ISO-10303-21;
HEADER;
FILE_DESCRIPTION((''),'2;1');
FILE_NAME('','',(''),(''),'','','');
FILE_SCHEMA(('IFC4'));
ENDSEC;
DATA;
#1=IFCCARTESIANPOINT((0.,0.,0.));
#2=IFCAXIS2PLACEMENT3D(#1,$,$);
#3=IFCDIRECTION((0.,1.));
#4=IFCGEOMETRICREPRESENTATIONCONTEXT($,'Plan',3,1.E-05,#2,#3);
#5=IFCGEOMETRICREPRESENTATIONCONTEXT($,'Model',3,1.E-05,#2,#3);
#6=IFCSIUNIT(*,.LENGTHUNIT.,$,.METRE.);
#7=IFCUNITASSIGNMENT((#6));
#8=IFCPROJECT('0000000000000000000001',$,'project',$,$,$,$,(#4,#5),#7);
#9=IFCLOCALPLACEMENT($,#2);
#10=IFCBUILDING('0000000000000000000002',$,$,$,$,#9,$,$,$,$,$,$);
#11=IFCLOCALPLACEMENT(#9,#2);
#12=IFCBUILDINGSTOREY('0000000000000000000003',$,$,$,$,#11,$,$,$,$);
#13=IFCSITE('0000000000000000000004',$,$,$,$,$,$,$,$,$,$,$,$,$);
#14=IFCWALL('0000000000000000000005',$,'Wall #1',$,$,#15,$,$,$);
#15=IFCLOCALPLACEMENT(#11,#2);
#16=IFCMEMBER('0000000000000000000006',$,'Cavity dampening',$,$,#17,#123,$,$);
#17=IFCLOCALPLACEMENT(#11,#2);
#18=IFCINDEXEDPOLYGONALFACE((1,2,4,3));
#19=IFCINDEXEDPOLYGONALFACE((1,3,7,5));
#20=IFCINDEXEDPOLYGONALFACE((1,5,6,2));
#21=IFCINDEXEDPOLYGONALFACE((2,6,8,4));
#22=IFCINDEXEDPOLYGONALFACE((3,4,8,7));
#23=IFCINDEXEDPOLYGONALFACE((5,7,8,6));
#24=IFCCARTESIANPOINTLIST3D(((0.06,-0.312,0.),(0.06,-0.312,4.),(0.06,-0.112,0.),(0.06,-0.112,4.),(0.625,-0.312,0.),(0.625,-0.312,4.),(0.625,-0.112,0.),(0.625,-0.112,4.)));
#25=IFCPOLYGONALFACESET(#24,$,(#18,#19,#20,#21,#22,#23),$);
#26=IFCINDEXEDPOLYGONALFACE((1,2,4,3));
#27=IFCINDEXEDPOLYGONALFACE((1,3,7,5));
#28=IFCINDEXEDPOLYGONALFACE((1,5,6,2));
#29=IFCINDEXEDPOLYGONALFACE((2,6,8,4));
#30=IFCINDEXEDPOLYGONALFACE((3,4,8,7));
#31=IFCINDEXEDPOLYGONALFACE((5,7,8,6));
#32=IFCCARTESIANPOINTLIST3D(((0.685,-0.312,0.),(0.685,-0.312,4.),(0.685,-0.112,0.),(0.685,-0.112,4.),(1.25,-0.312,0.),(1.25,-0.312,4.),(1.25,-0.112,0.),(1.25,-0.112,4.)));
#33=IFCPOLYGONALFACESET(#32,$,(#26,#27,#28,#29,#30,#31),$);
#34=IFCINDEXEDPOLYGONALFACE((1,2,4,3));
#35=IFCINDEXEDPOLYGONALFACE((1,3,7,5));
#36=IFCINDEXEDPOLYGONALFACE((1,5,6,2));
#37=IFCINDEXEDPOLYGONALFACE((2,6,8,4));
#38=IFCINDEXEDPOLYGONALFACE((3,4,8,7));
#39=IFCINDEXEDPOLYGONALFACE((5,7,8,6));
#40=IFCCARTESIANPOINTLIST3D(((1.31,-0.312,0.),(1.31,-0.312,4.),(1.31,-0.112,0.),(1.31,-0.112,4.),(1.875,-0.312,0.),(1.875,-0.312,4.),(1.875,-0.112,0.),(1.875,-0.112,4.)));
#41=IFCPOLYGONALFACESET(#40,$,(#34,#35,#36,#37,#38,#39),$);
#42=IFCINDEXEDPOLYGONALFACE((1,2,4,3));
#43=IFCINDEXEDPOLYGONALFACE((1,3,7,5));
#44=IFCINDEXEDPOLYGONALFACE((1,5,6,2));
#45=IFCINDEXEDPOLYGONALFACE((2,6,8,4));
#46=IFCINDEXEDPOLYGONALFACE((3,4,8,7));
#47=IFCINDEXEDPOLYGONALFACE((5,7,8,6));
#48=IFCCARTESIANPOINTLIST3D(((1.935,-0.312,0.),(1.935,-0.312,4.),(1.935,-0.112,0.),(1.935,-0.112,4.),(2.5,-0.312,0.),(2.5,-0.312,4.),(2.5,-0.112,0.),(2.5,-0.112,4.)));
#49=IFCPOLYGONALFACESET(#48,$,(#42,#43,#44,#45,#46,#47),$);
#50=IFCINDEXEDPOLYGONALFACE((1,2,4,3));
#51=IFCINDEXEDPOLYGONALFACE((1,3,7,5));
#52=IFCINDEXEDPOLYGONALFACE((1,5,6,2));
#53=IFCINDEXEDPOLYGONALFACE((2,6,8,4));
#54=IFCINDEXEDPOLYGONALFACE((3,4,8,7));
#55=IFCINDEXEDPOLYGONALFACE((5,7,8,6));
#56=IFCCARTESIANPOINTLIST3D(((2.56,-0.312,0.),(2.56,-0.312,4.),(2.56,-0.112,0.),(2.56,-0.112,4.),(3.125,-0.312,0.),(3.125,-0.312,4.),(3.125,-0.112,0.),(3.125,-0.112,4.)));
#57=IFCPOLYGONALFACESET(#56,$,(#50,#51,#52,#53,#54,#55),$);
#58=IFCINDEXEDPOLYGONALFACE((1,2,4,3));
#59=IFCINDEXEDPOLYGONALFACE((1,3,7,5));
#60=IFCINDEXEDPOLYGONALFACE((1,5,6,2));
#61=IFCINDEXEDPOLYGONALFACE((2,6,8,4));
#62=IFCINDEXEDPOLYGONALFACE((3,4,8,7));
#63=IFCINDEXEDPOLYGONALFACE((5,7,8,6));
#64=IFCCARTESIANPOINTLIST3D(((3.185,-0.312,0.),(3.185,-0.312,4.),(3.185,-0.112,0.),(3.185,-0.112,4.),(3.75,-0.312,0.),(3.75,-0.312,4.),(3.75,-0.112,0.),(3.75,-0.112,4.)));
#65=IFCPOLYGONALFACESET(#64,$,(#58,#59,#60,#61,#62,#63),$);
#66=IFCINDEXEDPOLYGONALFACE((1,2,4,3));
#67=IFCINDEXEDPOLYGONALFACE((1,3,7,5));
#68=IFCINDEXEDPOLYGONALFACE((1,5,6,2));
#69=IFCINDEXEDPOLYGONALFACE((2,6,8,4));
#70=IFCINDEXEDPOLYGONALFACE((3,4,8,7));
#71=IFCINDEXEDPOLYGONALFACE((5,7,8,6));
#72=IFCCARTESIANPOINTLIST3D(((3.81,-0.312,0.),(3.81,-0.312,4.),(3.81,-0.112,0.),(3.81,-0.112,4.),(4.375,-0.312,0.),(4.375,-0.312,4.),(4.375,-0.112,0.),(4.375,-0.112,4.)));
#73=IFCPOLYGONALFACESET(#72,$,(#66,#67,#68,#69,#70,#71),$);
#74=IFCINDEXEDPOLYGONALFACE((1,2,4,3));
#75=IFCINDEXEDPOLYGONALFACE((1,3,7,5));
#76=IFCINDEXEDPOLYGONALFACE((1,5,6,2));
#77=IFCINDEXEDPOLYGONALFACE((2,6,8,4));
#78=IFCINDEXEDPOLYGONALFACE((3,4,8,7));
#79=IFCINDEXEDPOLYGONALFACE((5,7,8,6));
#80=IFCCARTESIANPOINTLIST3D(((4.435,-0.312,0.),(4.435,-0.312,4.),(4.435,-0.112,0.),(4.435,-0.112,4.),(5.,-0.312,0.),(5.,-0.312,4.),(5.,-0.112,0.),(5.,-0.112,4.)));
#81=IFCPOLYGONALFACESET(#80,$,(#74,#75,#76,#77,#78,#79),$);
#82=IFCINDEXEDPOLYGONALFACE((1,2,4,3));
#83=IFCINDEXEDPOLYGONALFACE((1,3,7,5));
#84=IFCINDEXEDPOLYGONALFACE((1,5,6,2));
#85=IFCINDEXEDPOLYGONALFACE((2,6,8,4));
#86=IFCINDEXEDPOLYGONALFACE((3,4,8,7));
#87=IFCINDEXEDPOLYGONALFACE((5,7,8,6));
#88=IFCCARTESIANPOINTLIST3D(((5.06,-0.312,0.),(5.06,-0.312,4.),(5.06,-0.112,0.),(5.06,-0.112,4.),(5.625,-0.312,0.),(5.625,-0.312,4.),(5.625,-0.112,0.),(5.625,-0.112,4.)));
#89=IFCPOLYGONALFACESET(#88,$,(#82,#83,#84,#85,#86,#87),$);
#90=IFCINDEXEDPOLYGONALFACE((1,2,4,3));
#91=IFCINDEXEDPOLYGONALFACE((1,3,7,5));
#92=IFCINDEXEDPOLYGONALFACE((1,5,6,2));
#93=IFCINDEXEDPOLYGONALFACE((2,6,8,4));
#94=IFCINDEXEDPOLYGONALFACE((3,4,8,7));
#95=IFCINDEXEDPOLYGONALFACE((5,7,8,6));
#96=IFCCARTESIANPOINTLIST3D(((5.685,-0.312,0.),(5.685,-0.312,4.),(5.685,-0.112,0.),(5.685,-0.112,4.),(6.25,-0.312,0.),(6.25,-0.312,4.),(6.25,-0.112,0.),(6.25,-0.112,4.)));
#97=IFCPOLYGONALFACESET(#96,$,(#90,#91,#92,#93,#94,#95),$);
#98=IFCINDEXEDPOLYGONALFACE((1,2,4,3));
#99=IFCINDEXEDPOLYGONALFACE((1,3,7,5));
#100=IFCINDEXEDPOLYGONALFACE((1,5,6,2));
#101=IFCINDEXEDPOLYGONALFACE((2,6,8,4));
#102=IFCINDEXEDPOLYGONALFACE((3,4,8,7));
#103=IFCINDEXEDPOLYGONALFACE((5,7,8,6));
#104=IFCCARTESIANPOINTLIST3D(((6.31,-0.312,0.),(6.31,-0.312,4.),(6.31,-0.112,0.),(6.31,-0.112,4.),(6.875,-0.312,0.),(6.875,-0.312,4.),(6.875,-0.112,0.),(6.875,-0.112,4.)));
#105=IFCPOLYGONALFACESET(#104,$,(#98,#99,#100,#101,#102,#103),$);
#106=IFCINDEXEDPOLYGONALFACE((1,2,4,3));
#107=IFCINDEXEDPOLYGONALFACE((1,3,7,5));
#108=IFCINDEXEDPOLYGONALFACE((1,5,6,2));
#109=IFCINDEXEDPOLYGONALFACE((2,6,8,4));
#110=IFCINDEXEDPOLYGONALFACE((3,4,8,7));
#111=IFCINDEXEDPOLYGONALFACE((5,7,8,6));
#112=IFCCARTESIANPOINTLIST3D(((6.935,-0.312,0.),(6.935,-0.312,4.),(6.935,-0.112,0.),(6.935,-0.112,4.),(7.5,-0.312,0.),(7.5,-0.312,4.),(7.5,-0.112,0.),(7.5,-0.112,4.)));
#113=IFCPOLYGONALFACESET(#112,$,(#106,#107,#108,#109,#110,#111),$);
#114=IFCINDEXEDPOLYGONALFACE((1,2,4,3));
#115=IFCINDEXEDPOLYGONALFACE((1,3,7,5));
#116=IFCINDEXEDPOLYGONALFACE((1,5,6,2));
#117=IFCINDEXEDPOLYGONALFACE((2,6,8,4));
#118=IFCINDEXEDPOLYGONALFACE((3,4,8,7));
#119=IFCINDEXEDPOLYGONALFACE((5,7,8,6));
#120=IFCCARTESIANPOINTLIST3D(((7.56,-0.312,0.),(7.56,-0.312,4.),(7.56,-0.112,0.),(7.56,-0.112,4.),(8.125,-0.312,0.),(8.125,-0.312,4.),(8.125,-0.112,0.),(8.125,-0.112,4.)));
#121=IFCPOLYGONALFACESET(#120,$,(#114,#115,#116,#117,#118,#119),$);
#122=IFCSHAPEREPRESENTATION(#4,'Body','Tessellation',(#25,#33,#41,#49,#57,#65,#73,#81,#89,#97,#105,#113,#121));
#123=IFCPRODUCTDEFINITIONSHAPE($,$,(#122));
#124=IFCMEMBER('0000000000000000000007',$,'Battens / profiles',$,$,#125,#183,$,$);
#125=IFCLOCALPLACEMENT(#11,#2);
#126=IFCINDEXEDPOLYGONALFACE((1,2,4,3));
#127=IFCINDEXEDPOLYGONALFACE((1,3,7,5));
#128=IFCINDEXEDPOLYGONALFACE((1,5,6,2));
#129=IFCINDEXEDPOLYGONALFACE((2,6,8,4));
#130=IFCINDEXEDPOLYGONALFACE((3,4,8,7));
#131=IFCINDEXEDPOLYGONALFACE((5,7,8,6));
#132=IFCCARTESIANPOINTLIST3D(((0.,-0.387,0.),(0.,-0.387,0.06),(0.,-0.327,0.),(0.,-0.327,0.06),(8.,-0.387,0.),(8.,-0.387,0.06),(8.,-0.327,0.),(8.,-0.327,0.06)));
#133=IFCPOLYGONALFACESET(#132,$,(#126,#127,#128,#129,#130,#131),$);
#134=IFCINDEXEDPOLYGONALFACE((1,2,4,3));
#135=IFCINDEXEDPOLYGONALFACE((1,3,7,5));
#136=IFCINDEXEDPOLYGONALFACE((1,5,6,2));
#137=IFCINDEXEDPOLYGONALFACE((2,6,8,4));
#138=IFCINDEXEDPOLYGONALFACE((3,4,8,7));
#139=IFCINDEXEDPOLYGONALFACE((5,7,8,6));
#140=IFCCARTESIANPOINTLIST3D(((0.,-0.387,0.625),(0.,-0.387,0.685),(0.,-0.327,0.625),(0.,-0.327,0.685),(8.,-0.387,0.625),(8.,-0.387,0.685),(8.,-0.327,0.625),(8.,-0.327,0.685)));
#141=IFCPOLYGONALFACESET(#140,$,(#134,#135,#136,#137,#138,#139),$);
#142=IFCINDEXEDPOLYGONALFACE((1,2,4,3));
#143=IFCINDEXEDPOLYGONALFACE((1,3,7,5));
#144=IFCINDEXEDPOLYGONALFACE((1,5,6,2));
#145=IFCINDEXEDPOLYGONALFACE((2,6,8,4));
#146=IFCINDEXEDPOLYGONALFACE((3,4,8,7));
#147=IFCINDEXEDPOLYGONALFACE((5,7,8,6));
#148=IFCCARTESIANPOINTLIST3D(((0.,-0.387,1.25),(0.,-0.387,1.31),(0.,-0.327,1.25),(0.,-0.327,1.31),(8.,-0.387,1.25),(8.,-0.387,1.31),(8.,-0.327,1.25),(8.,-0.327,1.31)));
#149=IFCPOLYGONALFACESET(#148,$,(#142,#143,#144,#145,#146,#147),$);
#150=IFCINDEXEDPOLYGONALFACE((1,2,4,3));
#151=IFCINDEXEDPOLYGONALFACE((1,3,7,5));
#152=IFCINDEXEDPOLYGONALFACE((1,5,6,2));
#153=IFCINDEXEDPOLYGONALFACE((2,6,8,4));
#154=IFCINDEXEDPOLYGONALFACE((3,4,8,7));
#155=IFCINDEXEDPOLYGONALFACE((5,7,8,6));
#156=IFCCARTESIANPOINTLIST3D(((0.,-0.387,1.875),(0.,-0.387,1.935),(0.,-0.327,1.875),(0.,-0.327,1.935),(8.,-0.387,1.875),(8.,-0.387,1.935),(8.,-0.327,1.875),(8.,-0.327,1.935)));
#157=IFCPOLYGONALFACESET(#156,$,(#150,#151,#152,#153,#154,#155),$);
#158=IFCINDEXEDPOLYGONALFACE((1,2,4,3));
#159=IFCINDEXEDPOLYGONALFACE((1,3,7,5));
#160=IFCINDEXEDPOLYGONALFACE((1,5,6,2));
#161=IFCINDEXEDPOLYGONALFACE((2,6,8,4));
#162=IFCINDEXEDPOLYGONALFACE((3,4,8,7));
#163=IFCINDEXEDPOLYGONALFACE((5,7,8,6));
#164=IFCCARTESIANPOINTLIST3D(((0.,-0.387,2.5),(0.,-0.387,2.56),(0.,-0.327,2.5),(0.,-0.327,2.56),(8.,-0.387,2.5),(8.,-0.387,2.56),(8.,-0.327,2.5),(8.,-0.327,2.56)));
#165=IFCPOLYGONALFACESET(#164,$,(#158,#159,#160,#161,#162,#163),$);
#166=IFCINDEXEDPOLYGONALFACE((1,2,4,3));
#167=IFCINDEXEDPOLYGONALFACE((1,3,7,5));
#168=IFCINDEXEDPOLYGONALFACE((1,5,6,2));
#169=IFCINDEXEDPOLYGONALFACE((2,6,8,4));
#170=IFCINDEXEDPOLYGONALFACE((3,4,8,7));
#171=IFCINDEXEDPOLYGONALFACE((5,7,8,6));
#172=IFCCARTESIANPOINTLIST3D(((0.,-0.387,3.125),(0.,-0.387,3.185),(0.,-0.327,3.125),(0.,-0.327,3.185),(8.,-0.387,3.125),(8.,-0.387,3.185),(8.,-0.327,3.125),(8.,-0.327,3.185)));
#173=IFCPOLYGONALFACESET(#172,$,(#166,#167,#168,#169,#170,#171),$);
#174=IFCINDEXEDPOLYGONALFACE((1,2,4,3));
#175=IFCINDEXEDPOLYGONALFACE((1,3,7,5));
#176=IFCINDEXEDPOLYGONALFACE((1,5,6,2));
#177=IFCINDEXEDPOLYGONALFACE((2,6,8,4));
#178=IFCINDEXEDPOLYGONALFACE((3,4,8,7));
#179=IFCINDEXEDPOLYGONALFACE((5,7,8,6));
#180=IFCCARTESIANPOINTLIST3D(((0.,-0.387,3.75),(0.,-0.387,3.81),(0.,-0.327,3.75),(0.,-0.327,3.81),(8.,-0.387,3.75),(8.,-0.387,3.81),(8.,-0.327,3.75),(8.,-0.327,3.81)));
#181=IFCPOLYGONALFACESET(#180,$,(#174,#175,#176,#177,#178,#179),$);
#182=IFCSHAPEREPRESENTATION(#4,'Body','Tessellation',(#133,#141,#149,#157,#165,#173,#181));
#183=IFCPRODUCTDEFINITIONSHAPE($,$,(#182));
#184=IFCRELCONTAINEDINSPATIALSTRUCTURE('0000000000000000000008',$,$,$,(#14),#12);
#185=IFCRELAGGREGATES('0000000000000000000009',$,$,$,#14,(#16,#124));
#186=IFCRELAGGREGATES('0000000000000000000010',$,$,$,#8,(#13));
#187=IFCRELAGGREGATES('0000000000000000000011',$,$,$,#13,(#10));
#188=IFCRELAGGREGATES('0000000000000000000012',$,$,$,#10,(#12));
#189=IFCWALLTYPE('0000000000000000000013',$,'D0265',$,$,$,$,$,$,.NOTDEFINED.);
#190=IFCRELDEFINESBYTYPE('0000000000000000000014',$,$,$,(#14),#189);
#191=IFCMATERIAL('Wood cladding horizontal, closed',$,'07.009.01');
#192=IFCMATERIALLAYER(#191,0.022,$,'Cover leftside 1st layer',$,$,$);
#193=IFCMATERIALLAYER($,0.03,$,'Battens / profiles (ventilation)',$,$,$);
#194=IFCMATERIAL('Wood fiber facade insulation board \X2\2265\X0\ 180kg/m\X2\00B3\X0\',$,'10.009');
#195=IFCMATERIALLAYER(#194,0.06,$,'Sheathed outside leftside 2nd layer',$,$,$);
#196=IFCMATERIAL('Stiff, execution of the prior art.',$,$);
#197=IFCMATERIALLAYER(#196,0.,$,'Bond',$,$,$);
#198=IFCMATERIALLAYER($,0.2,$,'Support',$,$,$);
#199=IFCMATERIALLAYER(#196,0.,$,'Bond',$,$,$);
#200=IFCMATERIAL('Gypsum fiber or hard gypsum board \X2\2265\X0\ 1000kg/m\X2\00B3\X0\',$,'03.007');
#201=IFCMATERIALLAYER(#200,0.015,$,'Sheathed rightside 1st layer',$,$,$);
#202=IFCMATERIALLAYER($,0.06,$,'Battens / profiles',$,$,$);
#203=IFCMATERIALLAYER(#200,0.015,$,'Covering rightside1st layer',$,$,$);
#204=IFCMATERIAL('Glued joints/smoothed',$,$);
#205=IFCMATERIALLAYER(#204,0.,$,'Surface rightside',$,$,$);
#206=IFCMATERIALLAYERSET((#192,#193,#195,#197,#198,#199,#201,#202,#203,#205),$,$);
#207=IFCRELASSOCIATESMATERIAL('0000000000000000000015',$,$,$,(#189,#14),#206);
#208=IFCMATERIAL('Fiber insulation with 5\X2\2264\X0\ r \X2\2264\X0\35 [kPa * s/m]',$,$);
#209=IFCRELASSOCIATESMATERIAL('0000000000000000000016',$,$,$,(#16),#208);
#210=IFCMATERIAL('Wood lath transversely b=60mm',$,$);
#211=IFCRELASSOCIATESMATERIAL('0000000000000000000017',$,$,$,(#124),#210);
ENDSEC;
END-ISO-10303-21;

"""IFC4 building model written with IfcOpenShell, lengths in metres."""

from ifc_helpers import new_model, si_unit, direction, frame, frame_2d, origin, place, context, project, spatial, rectangle, extrude, material, layer, layer_set, type_object, element, aggregate, save


model = new_model("IFC4")

# Units and contexts
plan_context = context("Plan", 3, precision=1e-05, world=origin(), true_north=direction((0.0, 1.0)))
model_context = context("Model", 3, precision=1e-05, world=origin(), true_north=direction((0.0, 1.0)))
ifc_project = project(units=[si_unit("LENGTHUNIT", "METRE")], contexts=[plan_context, model_context])

# Site, building, storey
site = spatial("IfcSite", under=ifc_project)
building_placement = place(None, origin())
building = spatial("IfcBuilding", under=site, at=building_placement)
storey_placement = place(building_placement, origin())
storey = spatial("IfcBuildingStorey", under=building, at=storey_placement)

# Wall, members
ifc_material_1 = material(Name="Wood cladding horizontal, closed", Category="07.009.01")
ifc_layer_1 = layer(ifc_material_1, 0.022, Name="Cover leftside 1st layer")
ifc_layer_2 = layer(None, 0.03, Name="Battens / profiles (ventilation)")
ifc_material_2 = material(Name="Wood fiber facade insulation board ≥ 180kg/m³", Category="10.009")
ifc_layer_3 = layer(ifc_material_2, 0.06, Name="Sheathed outside leftside 2nd layer")
ifc_material_3 = material(Name="Stiff, execution of the prior art.")
ifc_layer_4 = layer(ifc_material_3, 0.0, Name="Bond")
ifc_layer_5 = layer(None, 0.2, Name="Support")
ifc_layer_6 = layer(ifc_material_3, 0.0, Name="Bond")
ifc_material_4 = material(Name="Gypsum fiber or hard gypsum board ≥ 1000kg/m³", Category="03.007")
ifc_layer_7 = layer(ifc_material_4, 0.015, Name="Sheathed rightside 1st layer")
ifc_layer_8 = layer(None, 0.06, Name="Battens / profiles")
ifc_layer_9 = layer(ifc_material_4, 0.015, Name="Covering rightside1st layer")
ifc_material_5 = material(Name="Glued joints/smoothed")
ifc_layer_10 = layer(ifc_material_5, 0.0, Name="Surface rightside")
ifc_layer_set = layer_set([ifc_layer_1, ifc_layer_2, ifc_layer_3, ifc_layer_4, ifc_layer_5, ifc_layer_6, ifc_layer_7, ifc_layer_8, ifc_layer_9, ifc_layer_10])
wall_type = type_object("IfcWallType", Name="D0265", PredefinedType="NOTDEFINED", material=ifc_layer_set)
wall_placement = place(None, frame((0.0, 0.0, 0.0), z_axis=(0.0, -1.0, 0.0), x_axis=(1.0, 0.0, 0.0)))
wall = element("IfcWall", 1, at=wall_placement, inside=storey, type_object=wall_type, material=ifc_layer_set, Name="Wall #1")
ifc_material_6 = material(Name="Fiber insulation with 5≤ r ≤35 [kPa * s/m]")
member_1_placement = place(wall_placement, origin())
member_1 = element("IfcMember", 2, at=member_1_placement, material=ifc_material_6, Name="Cavity dampening", context=plan_context, shape_type="SweptSolid", body=[
    extrude(rectangle(XDim=0.565, YDim=0.2, at=frame_2d((0.2825, 0.1), x_axis=(1.0, 0.0))), frame((0.06, 4.0, 0.112), z_axis=(0.0, -1.0, 0.0), x_axis=(1.0, 0.0, 0.0)), (0.0, 0.0, 1.0), 4.0),
    extrude(rectangle(XDim=0.565, YDim=0.2, at=frame_2d((0.2825, 0.1), x_axis=(1.0, 0.0))), frame((0.685, 4.0, 0.112), z_axis=(0.0, -1.0, 0.0), x_axis=(1.0, 0.0, 0.0)), (0.0, 0.0, 1.0), 4.0),
    extrude(rectangle(XDim=0.565, YDim=0.2, at=frame_2d((0.2825, 0.1), x_axis=(1.0, 0.0))), frame((1.31, 4.0, 0.112), z_axis=(0.0, -1.0, 0.0), x_axis=(1.0, 0.0, 0.0)), (0.0, 0.0, 1.0), 4.0),
    extrude(rectangle(XDim=0.565, YDim=0.2, at=frame_2d((0.2825, 0.1), x_axis=(1.0, 0.0))), frame((1.935, 4.0, 0.112), z_axis=(0.0, -1.0, 0.0), x_axis=(1.0, 0.0, 0.0)), (0.0, 0.0, 1.0), 4.0),
    extrude(rectangle(XDim=0.565, YDim=0.2, at=frame_2d((0.2825, 0.1), x_axis=(1.0, 0.0))), frame((2.56, 4.0, 0.112), z_axis=(0.0, -1.0, 0.0), x_axis=(1.0, 0.0, 0.0)), (0.0, 0.0, 1.0), 4.0),
    extrude(rectangle(XDim=0.565, YDim=0.2, at=frame_2d((0.2825, 0.1), x_axis=(1.0, 0.0))), frame((3.185, 4.0, 0.112), z_axis=(0.0, -1.0, 0.0), x_axis=(1.0, 0.0, 0.0)), (0.0, 0.0, 1.0), 4.0),
    extrude(rectangle(XDim=0.565, YDim=0.2, at=frame_2d((0.2825, 0.1), x_axis=(1.0, 0.0))), frame((3.81, 4.0, 0.112), z_axis=(0.0, -1.0, 0.0), x_axis=(1.0, 0.0, 0.0)), (0.0, 0.0, 1.0), 4.0),
    extrude(rectangle(XDim=0.565, YDim=0.2, at=frame_2d((0.2825, 0.1), x_axis=(1.0, 0.0))), frame((4.435, 4.0, 0.112), z_axis=(0.0, -1.0, 0.0), x_axis=(1.0, 0.0, 0.0)), (0.0, 0.0, 1.0), 4.0),
    extrude(rectangle(XDim=0.565, YDim=0.2, at=frame_2d((0.2825, 0.1), x_axis=(1.0, 0.0))), frame((5.06, 4.0, 0.112), z_axis=(0.0, -1.0, 0.0), x_axis=(1.0, 0.0, 0.0)), (0.0, 0.0, 1.0), 4.0),
    extrude(rectangle(XDim=0.565, YDim=0.2, at=frame_2d((0.2825, 0.1), x_axis=(1.0, 0.0))), frame((5.685, 4.0, 0.112), z_axis=(0.0, -1.0, 0.0), x_axis=(1.0, 0.0, 0.0)), (0.0, 0.0, 1.0), 4.0),
    extrude(rectangle(XDim=0.565, YDim=0.2, at=frame_2d((0.2825, 0.1), x_axis=(1.0, 0.0))), frame((6.31, 4.0, 0.112), z_axis=(0.0, -1.0, 0.0), x_axis=(1.0, 0.0, 0.0)), (0.0, 0.0, 1.0), 4.0),
    extrude(rectangle(XDim=0.565, YDim=0.2, at=frame_2d((0.2825, 0.1), x_axis=(1.0, 0.0))), frame((6.935, 4.0, 0.112), z_axis=(0.0, -1.0, 0.0), x_axis=(1.0, 0.0, 0.0)), (0.0, 0.0, 1.0), 4.0),
    extrude(rectangle(XDim=0.565, YDim=0.2, at=frame_2d((0.2825, 0.1), x_axis=(1.0, 0.0))), frame((7.56, 4.0, 0.112), z_axis=(0.0, -1.0, 0.0), x_axis=(1.0, 0.0, 0.0)), (0.0, 0.0, 1.0), 4.0),
])
ifc_material_7 = material(Name="Wood lath transversely b=60mm")
member_2_placement = place(wall_placement, origin())
member_2 = element("IfcMember", 3, at=member_2_placement, material=ifc_material_7, Name="Battens / profiles", context=plan_context, shape_type="SweptSolid", body=[
    extrude(rectangle(XDim=0.06, YDim=0.06, at=frame_2d((0.03, 0.03), x_axis=(1.0, 0.0))), frame((0.0, 0.0, 0.327), z_axis=(1.0, 0.0, 0.0), x_axis=(0.0, 1.0, 0.0)), (0.0, 0.0, 1.0), 8.0),
    extrude(rectangle(XDim=0.06, YDim=0.06, at=frame_2d((0.03, 0.03), x_axis=(1.0, 0.0))), frame((0.0, 0.625, 0.327), z_axis=(1.0, 0.0, 0.0), x_axis=(0.0, 1.0, 0.0)), (0.0, 0.0, 1.0), 8.0),
    extrude(rectangle(XDim=0.06, YDim=0.06, at=frame_2d((0.03, 0.03), x_axis=(1.0, 0.0))), frame((0.0, 1.25, 0.327), z_axis=(1.0, 0.0, 0.0), x_axis=(0.0, 1.0, 0.0)), (0.0, 0.0, 1.0), 8.0),
    extrude(rectangle(XDim=0.06, YDim=0.06, at=frame_2d((0.03, 0.03), x_axis=(1.0, 0.0))), frame((0.0, 1.875, 0.327), z_axis=(1.0, 0.0, 0.0), x_axis=(0.0, 1.0, 0.0)), (0.0, 0.0, 1.0), 8.0),
    extrude(rectangle(XDim=0.06, YDim=0.06, at=frame_2d((0.03, 0.03), x_axis=(1.0, 0.0))), frame((0.0, 2.5, 0.327), z_axis=(1.0, 0.0, 0.0), x_axis=(0.0, 1.0, 0.0)), (0.0, 0.0, 1.0), 8.0),
    extrude(rectangle(XDim=0.06, YDim=0.06, at=frame_2d((0.03, 0.03), x_axis=(1.0, 0.0))), frame((0.0, 3.125, 0.327), z_axis=(1.0, 0.0, 0.0), x_axis=(0.0, 1.0, 0.0)), (0.0, 0.0, 1.0), 8.0),
    extrude(rectangle(XDim=0.06, YDim=0.06, at=frame_2d((0.03, 0.03), x_axis=(1.0, 0.0))), frame((0.0, 3.75, 0.327), z_axis=(1.0, 0.0, 0.0), x_axis=(0.0, 1.0, 0.0)), (0.0, 0.0, 1.0), 8.0),
])
aggregate(wall, [member_1, member_2])

save(model, "model.ifc")
